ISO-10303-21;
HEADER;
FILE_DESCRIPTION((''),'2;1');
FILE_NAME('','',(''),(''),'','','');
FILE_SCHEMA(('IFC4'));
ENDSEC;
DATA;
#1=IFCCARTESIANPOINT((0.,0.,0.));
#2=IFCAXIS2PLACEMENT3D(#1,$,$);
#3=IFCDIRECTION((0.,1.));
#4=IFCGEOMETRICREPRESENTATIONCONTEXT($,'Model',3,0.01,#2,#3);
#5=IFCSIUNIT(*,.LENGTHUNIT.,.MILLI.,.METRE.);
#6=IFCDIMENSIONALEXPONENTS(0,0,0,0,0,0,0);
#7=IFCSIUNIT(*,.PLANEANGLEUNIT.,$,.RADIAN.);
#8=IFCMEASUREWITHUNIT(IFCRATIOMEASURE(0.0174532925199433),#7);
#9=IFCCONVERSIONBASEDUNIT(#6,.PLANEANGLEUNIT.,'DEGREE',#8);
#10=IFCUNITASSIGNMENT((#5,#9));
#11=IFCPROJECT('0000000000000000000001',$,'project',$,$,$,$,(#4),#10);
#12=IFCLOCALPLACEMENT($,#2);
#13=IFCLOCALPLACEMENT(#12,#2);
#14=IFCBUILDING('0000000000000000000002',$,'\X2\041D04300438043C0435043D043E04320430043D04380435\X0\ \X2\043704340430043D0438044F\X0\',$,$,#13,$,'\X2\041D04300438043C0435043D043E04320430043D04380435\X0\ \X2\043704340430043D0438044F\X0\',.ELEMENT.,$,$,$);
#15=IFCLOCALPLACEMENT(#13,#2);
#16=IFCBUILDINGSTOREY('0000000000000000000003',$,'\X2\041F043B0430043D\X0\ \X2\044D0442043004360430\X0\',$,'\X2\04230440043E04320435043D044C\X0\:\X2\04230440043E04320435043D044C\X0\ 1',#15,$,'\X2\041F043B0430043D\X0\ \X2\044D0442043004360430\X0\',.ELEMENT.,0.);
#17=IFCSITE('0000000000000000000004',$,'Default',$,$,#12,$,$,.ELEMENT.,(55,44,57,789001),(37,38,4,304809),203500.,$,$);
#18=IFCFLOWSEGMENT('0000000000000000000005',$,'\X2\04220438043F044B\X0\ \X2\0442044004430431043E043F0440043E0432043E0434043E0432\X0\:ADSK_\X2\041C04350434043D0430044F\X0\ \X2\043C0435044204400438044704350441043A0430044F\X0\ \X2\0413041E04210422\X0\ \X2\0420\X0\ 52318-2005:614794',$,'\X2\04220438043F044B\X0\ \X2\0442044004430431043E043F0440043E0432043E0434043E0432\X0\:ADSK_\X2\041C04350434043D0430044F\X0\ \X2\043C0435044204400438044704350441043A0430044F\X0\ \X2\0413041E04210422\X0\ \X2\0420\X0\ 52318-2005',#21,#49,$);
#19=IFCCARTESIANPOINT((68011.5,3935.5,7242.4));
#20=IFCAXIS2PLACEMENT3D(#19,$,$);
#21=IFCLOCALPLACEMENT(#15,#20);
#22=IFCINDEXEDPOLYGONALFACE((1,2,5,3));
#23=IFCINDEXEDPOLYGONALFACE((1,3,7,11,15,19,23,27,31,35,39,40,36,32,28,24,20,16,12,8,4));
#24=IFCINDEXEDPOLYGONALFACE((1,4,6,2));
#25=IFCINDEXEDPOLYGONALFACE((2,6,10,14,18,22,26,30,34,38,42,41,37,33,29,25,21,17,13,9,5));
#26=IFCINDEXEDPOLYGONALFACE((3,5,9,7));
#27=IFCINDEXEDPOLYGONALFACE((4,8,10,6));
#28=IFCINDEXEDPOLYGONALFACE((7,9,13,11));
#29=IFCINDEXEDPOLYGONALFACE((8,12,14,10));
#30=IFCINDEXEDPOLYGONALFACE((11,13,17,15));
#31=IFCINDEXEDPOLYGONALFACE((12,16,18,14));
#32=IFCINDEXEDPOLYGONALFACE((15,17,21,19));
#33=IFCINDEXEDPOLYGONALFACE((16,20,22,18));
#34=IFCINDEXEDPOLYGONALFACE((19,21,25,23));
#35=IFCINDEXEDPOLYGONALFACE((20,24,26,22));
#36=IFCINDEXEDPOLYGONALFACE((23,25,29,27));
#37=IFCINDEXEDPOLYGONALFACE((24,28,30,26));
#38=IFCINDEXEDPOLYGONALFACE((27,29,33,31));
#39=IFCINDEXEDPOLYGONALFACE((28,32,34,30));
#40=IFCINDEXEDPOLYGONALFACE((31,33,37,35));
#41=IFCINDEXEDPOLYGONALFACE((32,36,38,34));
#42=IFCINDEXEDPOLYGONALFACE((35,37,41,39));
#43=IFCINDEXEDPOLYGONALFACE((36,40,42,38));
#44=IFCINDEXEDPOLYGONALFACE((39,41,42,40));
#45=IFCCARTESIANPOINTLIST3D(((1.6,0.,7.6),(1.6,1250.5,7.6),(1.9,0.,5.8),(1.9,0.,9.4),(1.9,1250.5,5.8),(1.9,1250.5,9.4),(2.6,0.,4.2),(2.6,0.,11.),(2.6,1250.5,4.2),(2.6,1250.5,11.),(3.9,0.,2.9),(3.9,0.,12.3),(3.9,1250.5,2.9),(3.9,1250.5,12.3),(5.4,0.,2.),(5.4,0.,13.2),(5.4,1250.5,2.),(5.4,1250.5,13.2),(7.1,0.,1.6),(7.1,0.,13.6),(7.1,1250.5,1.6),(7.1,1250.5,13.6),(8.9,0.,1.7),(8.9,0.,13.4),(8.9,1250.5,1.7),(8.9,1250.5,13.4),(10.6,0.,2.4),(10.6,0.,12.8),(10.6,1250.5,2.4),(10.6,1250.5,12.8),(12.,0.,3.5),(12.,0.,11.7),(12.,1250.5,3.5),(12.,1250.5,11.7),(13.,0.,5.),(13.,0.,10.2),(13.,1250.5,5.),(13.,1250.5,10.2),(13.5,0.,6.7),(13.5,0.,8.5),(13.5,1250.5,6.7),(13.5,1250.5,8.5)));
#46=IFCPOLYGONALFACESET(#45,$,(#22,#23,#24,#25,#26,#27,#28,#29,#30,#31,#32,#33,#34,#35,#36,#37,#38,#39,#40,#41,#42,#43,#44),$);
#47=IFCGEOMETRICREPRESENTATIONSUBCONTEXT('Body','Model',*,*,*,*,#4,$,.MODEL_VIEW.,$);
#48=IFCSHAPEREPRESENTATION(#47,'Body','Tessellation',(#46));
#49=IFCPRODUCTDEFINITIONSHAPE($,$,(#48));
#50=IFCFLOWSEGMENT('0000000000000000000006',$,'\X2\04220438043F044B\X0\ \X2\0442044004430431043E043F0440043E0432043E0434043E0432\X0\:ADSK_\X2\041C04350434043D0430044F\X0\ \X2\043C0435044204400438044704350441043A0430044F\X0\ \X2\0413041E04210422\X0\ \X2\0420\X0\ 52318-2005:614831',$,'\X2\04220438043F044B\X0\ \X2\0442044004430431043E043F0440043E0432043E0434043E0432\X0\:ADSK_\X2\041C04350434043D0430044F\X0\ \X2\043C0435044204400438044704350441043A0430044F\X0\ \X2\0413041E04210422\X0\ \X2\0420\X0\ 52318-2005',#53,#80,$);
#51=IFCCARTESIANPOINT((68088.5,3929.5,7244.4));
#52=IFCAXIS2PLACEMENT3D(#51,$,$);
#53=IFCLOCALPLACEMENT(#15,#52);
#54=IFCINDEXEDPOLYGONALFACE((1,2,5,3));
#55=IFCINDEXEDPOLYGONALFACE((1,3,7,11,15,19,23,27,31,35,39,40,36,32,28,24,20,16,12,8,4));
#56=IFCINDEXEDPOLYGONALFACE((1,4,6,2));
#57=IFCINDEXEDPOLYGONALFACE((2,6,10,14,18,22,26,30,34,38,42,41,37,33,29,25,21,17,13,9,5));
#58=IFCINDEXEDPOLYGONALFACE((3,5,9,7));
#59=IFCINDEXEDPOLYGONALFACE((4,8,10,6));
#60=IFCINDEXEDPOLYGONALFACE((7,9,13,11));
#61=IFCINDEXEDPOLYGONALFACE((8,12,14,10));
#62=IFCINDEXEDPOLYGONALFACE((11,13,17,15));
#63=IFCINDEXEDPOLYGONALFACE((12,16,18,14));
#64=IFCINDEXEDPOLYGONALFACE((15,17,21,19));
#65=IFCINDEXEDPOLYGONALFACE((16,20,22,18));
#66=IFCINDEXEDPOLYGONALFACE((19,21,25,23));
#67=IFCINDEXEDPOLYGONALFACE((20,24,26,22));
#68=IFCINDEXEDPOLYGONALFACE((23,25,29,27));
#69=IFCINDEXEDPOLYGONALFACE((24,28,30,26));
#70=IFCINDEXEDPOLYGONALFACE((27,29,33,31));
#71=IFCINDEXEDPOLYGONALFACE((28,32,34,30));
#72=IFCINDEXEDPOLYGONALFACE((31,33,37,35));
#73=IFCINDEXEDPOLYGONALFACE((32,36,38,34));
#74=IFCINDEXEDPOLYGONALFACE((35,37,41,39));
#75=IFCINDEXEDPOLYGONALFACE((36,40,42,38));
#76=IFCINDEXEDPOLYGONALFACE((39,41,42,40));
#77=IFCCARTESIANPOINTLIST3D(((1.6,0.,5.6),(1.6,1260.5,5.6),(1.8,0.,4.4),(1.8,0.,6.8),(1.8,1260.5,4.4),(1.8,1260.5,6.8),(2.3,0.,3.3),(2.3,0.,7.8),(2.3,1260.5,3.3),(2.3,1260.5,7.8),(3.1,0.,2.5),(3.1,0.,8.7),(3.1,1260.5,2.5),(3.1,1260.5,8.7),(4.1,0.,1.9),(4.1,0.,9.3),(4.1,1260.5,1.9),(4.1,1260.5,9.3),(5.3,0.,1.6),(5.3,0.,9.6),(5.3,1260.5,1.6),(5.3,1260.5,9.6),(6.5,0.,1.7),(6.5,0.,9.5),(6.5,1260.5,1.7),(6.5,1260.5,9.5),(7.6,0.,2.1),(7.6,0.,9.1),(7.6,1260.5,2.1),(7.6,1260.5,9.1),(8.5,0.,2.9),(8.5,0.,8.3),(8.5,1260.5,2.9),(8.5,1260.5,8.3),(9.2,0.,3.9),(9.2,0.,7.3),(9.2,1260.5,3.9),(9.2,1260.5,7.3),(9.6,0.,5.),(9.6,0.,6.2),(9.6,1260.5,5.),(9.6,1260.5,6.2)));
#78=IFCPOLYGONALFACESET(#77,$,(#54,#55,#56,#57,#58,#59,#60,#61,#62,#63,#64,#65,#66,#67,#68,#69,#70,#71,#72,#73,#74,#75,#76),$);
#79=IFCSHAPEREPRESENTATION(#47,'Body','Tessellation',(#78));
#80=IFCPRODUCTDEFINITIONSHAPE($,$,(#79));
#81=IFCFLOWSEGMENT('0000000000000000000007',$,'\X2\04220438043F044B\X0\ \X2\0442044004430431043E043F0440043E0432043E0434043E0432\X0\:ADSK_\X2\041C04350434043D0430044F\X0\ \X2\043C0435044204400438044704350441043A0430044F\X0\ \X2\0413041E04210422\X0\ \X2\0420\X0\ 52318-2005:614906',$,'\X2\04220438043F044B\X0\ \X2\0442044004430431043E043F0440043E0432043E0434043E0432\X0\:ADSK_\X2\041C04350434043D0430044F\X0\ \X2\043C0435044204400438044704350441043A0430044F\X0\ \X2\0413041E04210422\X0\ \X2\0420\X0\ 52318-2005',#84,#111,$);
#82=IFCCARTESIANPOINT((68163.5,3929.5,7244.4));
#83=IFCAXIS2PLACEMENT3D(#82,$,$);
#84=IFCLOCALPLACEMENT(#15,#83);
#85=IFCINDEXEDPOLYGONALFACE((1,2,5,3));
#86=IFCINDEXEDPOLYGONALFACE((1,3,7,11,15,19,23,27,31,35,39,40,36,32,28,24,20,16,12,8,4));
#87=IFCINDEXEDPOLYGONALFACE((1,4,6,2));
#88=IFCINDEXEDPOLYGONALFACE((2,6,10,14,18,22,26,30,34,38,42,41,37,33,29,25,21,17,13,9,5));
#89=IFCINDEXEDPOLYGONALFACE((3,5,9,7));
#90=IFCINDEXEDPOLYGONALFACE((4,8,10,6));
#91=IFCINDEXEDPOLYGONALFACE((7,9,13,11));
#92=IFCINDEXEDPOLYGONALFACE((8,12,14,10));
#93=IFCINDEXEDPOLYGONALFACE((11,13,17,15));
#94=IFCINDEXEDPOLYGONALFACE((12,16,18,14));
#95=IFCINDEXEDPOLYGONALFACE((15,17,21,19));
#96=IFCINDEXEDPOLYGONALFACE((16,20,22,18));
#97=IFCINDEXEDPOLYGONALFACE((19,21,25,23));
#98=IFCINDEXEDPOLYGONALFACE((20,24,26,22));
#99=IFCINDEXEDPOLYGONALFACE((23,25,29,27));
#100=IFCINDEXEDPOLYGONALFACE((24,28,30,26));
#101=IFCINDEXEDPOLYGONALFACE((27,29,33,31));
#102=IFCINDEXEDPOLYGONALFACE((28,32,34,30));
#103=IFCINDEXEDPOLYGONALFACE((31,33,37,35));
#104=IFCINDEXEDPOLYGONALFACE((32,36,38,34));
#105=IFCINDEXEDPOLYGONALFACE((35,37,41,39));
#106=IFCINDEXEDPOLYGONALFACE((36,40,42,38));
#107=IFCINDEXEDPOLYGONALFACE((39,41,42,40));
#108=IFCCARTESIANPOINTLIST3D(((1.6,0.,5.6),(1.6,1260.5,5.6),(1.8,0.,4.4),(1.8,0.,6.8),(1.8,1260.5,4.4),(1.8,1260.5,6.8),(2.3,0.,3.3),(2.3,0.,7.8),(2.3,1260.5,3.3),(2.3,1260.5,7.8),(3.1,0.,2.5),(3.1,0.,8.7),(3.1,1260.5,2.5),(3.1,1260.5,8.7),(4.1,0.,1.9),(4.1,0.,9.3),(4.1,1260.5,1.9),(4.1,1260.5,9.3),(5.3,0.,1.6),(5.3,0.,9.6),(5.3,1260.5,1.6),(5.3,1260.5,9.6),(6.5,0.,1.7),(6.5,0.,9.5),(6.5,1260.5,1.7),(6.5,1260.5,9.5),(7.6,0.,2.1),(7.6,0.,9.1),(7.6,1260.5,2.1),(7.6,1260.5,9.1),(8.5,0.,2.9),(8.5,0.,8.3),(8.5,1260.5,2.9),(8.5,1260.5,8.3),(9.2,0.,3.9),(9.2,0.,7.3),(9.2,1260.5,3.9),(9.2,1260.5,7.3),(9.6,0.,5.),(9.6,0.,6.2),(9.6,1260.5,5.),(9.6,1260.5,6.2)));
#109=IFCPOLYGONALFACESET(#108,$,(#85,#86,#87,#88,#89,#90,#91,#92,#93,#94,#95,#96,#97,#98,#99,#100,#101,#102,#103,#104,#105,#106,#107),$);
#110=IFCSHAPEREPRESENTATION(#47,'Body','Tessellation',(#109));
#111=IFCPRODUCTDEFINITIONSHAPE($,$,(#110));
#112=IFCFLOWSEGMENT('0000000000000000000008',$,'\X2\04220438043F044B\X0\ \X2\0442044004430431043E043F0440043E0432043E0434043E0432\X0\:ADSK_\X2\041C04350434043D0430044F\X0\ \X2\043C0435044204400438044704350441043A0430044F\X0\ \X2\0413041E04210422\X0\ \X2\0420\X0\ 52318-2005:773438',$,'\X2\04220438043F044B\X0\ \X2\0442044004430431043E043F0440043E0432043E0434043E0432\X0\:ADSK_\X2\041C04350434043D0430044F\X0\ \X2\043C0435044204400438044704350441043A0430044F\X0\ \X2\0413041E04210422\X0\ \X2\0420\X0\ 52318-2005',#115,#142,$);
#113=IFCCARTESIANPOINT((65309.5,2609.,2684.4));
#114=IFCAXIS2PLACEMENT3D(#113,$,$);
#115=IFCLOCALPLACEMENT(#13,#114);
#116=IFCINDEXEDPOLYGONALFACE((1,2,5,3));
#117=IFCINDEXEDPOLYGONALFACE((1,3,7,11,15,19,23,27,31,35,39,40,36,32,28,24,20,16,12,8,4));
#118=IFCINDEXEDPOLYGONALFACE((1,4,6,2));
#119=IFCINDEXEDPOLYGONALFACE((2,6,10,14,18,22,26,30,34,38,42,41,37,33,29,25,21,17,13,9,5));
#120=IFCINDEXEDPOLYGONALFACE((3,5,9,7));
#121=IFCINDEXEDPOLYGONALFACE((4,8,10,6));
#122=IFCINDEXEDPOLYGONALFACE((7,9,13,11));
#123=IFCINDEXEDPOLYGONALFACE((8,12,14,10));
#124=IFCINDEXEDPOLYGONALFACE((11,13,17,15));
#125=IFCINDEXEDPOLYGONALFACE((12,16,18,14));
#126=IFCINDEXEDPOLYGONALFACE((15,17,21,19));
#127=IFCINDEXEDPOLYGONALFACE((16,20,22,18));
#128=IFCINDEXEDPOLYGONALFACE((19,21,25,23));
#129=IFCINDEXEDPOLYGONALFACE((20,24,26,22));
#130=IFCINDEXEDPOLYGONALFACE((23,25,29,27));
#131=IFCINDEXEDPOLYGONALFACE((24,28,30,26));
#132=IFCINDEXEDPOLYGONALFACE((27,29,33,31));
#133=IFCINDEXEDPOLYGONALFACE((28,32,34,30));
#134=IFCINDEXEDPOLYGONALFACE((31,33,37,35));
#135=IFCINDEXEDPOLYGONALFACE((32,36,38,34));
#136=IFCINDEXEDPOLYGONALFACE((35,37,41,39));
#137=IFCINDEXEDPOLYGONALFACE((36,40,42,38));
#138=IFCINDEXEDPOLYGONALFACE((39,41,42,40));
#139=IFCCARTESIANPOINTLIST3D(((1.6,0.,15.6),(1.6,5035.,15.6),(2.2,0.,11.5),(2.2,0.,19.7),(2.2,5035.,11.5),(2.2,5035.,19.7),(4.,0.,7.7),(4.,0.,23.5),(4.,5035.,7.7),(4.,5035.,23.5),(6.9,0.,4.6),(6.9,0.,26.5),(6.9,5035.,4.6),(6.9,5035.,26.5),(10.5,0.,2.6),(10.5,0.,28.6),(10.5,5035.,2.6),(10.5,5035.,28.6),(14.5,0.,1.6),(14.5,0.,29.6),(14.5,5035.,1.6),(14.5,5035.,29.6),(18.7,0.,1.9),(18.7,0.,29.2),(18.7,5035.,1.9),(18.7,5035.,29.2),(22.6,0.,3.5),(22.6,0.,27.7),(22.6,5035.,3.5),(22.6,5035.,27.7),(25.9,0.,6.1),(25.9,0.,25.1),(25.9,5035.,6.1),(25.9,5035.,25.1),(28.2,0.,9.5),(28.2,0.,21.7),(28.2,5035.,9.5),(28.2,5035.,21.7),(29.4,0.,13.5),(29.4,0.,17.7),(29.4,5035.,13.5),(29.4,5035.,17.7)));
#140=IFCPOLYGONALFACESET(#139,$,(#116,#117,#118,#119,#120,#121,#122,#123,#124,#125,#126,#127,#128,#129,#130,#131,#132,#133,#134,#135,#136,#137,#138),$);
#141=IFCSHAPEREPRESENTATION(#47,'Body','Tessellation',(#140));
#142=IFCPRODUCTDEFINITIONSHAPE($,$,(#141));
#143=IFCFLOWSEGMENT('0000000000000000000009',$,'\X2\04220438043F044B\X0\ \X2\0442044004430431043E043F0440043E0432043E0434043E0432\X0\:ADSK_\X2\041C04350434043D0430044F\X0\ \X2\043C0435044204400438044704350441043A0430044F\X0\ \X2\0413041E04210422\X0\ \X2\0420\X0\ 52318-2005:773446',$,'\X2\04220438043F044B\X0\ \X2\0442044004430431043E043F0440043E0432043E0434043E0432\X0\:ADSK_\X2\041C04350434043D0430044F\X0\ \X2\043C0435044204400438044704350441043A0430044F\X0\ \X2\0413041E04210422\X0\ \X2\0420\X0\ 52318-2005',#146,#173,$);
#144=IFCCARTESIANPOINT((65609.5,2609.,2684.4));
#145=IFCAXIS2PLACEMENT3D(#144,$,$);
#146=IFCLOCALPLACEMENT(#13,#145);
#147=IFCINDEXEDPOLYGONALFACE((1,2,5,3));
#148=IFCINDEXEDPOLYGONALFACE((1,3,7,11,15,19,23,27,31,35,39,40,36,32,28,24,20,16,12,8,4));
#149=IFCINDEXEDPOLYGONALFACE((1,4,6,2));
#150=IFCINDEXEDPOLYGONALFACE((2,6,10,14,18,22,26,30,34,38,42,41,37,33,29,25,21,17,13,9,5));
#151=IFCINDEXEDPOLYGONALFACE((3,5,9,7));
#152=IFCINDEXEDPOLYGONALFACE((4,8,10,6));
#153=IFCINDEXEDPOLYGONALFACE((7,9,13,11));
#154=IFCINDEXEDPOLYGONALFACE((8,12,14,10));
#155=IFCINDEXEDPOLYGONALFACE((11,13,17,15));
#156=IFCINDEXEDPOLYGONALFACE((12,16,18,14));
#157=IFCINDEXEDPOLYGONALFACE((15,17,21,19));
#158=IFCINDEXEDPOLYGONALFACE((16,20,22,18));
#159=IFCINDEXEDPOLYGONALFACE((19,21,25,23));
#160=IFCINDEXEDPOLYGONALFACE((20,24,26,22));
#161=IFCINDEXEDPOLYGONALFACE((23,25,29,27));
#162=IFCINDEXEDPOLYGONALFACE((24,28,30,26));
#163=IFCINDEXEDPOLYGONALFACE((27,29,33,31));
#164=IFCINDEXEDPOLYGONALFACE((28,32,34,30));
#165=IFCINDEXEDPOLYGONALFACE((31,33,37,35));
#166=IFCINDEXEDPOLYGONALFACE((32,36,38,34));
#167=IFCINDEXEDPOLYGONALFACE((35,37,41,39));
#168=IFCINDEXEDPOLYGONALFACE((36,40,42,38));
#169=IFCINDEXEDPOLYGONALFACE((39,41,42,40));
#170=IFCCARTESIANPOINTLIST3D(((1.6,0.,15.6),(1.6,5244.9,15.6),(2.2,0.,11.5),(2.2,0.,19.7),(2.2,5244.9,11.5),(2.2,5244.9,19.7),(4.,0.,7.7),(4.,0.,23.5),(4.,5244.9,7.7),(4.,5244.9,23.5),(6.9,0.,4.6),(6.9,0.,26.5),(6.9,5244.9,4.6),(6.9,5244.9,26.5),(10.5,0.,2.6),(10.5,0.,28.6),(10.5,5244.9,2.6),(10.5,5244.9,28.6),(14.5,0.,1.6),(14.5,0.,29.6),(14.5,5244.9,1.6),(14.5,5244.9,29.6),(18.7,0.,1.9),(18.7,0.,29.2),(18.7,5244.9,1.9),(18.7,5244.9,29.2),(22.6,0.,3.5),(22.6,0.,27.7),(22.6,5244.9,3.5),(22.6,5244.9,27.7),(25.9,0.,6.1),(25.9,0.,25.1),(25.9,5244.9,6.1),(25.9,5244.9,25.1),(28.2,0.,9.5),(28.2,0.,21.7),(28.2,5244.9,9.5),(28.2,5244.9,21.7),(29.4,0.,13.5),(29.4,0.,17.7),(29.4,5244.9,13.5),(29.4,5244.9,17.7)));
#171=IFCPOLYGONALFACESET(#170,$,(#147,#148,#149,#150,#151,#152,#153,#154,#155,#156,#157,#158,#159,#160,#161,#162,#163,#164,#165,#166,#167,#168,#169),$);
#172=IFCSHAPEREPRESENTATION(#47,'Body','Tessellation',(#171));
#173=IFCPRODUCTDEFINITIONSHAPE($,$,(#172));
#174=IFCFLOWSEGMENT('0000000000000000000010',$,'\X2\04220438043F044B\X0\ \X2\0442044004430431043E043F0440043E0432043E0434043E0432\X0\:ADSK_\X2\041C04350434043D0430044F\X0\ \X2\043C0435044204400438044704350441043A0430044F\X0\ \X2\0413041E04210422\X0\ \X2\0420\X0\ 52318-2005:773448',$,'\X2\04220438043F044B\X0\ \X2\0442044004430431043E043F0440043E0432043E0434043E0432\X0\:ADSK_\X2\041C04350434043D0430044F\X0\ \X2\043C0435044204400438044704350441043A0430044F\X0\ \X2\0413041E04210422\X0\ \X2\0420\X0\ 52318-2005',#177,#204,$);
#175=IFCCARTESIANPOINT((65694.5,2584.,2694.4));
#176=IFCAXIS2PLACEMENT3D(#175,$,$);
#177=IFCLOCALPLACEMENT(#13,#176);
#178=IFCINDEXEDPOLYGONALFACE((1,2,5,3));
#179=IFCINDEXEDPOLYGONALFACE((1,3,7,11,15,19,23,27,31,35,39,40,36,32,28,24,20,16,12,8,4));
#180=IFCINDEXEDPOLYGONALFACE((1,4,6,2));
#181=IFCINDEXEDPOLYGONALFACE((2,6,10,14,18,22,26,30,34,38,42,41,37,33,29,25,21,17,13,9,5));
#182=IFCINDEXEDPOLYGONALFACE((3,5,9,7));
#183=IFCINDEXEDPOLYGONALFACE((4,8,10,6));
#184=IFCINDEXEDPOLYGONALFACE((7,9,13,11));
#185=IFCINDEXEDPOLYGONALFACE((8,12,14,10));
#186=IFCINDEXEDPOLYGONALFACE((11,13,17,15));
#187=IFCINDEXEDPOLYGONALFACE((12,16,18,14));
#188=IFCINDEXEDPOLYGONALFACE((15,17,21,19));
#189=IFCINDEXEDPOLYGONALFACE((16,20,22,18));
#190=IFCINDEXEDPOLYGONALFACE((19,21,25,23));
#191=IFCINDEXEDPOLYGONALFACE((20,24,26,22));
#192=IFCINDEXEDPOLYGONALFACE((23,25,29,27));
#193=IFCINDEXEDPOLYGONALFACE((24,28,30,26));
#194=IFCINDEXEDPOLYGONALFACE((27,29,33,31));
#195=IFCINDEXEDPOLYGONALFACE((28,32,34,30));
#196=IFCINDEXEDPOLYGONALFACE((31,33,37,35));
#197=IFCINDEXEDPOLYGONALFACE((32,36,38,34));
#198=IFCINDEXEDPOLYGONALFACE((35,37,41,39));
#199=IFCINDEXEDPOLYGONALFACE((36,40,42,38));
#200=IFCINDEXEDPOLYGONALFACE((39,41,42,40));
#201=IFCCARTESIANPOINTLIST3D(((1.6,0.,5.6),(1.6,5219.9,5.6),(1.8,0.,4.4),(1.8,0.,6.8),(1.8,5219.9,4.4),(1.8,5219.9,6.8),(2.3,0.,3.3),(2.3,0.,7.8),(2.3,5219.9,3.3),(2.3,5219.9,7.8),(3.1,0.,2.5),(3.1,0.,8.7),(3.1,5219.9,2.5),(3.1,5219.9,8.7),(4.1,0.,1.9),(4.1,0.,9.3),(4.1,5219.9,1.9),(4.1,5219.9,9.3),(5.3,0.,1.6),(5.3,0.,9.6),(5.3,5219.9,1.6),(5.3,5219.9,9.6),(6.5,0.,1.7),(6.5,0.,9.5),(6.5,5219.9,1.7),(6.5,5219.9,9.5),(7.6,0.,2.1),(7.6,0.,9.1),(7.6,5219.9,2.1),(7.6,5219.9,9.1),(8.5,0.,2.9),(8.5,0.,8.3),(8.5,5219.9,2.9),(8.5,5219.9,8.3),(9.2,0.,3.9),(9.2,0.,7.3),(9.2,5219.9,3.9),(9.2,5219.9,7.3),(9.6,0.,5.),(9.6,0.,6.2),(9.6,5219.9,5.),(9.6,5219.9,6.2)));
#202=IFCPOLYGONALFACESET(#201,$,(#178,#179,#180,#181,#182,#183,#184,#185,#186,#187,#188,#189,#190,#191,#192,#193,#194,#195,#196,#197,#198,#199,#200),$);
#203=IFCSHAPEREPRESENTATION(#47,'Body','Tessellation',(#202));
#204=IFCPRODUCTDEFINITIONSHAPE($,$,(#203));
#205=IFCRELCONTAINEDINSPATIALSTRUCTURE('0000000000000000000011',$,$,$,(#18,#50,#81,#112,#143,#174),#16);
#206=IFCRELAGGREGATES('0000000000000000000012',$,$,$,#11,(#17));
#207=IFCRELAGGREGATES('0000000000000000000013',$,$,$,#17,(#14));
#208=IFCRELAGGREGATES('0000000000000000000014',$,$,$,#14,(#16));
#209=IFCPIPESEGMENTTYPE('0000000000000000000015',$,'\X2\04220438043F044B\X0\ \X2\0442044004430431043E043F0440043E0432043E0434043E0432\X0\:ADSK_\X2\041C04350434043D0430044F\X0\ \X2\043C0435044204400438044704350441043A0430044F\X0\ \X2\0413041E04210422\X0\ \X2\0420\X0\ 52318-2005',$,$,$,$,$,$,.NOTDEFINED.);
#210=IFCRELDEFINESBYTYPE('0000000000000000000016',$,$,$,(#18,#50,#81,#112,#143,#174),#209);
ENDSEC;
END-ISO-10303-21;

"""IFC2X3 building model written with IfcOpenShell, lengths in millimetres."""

from ifc_helpers import new_model, entity, si_unit, converted_unit, direction, frame, frame_2d, origin, origin_2d_with_axis, place, context, subcontext, project, spatial, circle, extrude, type_object, element, save


model = new_model("IFC2X3")

# Units and contexts
model_context = context("Model", 3, precision=0.01, world=origin(), true_north=direction((0.0, 1.0)))
body_context = subcontext(model_context, "Body", "Model", "MODEL_VIEW")
ifc_project = project(units=[si_unit("LENGTHUNIT", "METRE", prefix="MILLI"), converted_unit("PLANEANGLEUNIT", "DEGREE", entity("IfcRatioMeasure", 0.0174532925199433), si_unit("PLANEANGLEUNIT", "RADIAN"), dimensions=[0, 0, 0, 0, 0, 0, 0])], contexts=[model_context])

# Site, building, storey
site_placement = place(None, frame((0.0, 0.0, 0.0)))
site = spatial("IfcSite", under=ifc_project, at=site_placement, Name="Default", CompositionType="ELEMENT", RefLatitude=(55, 44, 57, 789001), RefLongitude=(37, 38, 4, 304809), RefElevation=203500.0)
building_placement = place(site_placement, origin())
building = spatial("IfcBuilding", under=site, at=building_placement, Name="Наименование здания", LongName="Наименование здания", CompositionType="ELEMENT")
storey_placement = place(building_placement, origin())
storey = spatial("IfcBuildingStorey", under=building, at=storey_placement, Name="План этажа", ObjectType="Уровень:Уровень 1", LongName="План этажа", CompositionType="ELEMENT", Elevation=0.0)

# Flow segments
pipe_segment_type = type_object("IfcPipeSegmentType", Name="Типы трубопроводов:ADSK_Медная метрическая ГОСТ Р 52318-2005", PredefinedType="NOTDEFINED")
flow_segment_1_placement = place(storey_placement, frame((68011.5, 3935.5, 7242.4)))
element("IfcFlowSegment", 1, at=flow_segment_1_placement, inside=storey, type_object=pipe_segment_type, Name="Типы трубопроводов:ADSK_Медная метрическая ГОСТ Р 52318-2005:614794", ObjectType="Типы трубопроводов:ADSK_Медная метрическая ГОСТ Р 52318-2005", context=body_context, shape_type="SweptSolid", body=[
    extrude(circle(Radius=6.0, at=frame_2d((0.0, 0.0), x_axis=(1.0, 0.0))), frame((7.6, 0.0, 7.6), z_axis=(0.0, 1.0, 0.0), x_axis=(-1.0, 0.0, 0.0)), (0.0, 0.0, 1.0), 1250.5),
])
flow_segment_2_placement = place(storey_placement, frame((68088.5, 3929.5, 7244.4)))
element("IfcFlowSegment", 2, at=flow_segment_2_placement, inside=storey, type_object=pipe_segment_type, Name="Типы трубопроводов:ADSK_Медная метрическая ГОСТ Р 52318-2005:614831", ObjectType="Типы трубопроводов:ADSK_Медная метрическая ГОСТ Р 52318-2005", context=body_context, shape_type="SweptSolid", body=[
    extrude(circle(Radius=4.0, at=frame_2d((0.0, 0.0), x_axis=(1.0, 0.0))), frame((5.6, 0.0, 5.6), z_axis=(0.0, 1.0, 0.0), x_axis=(-1.0, 0.0, 0.0)), (0.0, 0.0, 1.0), 1260.5),
])
flow_segment_3_placement = place(storey_placement, frame((68163.5, 3929.5, 7244.4)))
element("IfcFlowSegment", 3, at=flow_segment_3_placement, inside=storey, type_object=pipe_segment_type, Name="Типы трубопроводов:ADSK_Медная метрическая ГОСТ Р 52318-2005:614906", ObjectType="Типы трубопроводов:ADSK_Медная метрическая ГОСТ Р 52318-2005", context=body_context, shape_type="SweptSolid", body=[
    extrude(circle(Radius=4.0, at=frame_2d((0.0, 0.0), x_axis=(1.0, 0.0))), frame((5.6, 0.0, 5.6), z_axis=(0.0, 1.0, 0.0), x_axis=(-1.0, 0.0, 0.0)), (0.0, 0.0, 1.0), 1260.5),
])
flow_segment_4_placement = place(building_placement, frame((65309.5, 2609.0, 2684.4)))
element("IfcFlowSegment", 4, at=flow_segment_4_placement, inside=storey, type_object=pipe_segment_type, Name="Типы трубопроводов:ADSK_Медная метрическая ГОСТ Р 52318-2005:773438", ObjectType="Типы трубопроводов:ADSK_Медная метрическая ГОСТ Р 52318-2005", context=body_context, shape_type="SweptSolid", body=[
    extrude(circle(Radius=14.0, at=frame_2d((0.0, 0.0), x_axis=(1.0, 0.0))), frame((15.6, 0.0, 15.6), z_axis=(0.0, 1.0, 0.0), x_axis=(-1.0, 0.0, 0.0)), (0.0, 0.0, 1.0), 5035.0),
])
flow_segment_5_placement = place(building_placement, frame((65609.5, 2609.0, 2684.4)))
element("IfcFlowSegment", 5, at=flow_segment_5_placement, inside=storey, type_object=pipe_segment_type, Name="Типы трубопроводов:ADSK_Медная метрическая ГОСТ Р 52318-2005:773446", ObjectType="Типы трубопроводов:ADSK_Медная метрическая ГОСТ Р 52318-2005", context=body_context, shape_type="SweptSolid", body=[
    extrude(circle(Radius=14.0, at=frame_2d((0.0, 0.0), x_axis=(1.0, 0.0))), frame((15.6, 0.0, 15.6), z_axis=(0.0, 1.0, 0.0), x_axis=(-1.0, 0.0, 0.0)), (0.0, 0.0, 1.0), 5244.9),
])
flow_segment_6_placement = place(building_placement, frame((65694.5, 2584.0, 2694.4)))
element("IfcFlowSegment", 6, at=flow_segment_6_placement, inside=storey, type_object=pipe_segment_type, Name="Типы трубопроводов:ADSK_Медная метрическая ГОСТ Р 52318-2005:773448", ObjectType="Типы трубопроводов:ADSK_Медная метрическая ГОСТ Р 52318-2005", context=body_context, shape_type="SweptSolid", body=[
    extrude(circle(Radius=4.0, at=origin_2d_with_axis()), frame((5.6, 0.0, 5.6), z_axis=(0.0, 1.0, 0.0), x_axis=(-1.0, 0.0, 0.0)), (0.0, 0.0, 1.0), 5219.9),
])

save(model, "model.ifc")
